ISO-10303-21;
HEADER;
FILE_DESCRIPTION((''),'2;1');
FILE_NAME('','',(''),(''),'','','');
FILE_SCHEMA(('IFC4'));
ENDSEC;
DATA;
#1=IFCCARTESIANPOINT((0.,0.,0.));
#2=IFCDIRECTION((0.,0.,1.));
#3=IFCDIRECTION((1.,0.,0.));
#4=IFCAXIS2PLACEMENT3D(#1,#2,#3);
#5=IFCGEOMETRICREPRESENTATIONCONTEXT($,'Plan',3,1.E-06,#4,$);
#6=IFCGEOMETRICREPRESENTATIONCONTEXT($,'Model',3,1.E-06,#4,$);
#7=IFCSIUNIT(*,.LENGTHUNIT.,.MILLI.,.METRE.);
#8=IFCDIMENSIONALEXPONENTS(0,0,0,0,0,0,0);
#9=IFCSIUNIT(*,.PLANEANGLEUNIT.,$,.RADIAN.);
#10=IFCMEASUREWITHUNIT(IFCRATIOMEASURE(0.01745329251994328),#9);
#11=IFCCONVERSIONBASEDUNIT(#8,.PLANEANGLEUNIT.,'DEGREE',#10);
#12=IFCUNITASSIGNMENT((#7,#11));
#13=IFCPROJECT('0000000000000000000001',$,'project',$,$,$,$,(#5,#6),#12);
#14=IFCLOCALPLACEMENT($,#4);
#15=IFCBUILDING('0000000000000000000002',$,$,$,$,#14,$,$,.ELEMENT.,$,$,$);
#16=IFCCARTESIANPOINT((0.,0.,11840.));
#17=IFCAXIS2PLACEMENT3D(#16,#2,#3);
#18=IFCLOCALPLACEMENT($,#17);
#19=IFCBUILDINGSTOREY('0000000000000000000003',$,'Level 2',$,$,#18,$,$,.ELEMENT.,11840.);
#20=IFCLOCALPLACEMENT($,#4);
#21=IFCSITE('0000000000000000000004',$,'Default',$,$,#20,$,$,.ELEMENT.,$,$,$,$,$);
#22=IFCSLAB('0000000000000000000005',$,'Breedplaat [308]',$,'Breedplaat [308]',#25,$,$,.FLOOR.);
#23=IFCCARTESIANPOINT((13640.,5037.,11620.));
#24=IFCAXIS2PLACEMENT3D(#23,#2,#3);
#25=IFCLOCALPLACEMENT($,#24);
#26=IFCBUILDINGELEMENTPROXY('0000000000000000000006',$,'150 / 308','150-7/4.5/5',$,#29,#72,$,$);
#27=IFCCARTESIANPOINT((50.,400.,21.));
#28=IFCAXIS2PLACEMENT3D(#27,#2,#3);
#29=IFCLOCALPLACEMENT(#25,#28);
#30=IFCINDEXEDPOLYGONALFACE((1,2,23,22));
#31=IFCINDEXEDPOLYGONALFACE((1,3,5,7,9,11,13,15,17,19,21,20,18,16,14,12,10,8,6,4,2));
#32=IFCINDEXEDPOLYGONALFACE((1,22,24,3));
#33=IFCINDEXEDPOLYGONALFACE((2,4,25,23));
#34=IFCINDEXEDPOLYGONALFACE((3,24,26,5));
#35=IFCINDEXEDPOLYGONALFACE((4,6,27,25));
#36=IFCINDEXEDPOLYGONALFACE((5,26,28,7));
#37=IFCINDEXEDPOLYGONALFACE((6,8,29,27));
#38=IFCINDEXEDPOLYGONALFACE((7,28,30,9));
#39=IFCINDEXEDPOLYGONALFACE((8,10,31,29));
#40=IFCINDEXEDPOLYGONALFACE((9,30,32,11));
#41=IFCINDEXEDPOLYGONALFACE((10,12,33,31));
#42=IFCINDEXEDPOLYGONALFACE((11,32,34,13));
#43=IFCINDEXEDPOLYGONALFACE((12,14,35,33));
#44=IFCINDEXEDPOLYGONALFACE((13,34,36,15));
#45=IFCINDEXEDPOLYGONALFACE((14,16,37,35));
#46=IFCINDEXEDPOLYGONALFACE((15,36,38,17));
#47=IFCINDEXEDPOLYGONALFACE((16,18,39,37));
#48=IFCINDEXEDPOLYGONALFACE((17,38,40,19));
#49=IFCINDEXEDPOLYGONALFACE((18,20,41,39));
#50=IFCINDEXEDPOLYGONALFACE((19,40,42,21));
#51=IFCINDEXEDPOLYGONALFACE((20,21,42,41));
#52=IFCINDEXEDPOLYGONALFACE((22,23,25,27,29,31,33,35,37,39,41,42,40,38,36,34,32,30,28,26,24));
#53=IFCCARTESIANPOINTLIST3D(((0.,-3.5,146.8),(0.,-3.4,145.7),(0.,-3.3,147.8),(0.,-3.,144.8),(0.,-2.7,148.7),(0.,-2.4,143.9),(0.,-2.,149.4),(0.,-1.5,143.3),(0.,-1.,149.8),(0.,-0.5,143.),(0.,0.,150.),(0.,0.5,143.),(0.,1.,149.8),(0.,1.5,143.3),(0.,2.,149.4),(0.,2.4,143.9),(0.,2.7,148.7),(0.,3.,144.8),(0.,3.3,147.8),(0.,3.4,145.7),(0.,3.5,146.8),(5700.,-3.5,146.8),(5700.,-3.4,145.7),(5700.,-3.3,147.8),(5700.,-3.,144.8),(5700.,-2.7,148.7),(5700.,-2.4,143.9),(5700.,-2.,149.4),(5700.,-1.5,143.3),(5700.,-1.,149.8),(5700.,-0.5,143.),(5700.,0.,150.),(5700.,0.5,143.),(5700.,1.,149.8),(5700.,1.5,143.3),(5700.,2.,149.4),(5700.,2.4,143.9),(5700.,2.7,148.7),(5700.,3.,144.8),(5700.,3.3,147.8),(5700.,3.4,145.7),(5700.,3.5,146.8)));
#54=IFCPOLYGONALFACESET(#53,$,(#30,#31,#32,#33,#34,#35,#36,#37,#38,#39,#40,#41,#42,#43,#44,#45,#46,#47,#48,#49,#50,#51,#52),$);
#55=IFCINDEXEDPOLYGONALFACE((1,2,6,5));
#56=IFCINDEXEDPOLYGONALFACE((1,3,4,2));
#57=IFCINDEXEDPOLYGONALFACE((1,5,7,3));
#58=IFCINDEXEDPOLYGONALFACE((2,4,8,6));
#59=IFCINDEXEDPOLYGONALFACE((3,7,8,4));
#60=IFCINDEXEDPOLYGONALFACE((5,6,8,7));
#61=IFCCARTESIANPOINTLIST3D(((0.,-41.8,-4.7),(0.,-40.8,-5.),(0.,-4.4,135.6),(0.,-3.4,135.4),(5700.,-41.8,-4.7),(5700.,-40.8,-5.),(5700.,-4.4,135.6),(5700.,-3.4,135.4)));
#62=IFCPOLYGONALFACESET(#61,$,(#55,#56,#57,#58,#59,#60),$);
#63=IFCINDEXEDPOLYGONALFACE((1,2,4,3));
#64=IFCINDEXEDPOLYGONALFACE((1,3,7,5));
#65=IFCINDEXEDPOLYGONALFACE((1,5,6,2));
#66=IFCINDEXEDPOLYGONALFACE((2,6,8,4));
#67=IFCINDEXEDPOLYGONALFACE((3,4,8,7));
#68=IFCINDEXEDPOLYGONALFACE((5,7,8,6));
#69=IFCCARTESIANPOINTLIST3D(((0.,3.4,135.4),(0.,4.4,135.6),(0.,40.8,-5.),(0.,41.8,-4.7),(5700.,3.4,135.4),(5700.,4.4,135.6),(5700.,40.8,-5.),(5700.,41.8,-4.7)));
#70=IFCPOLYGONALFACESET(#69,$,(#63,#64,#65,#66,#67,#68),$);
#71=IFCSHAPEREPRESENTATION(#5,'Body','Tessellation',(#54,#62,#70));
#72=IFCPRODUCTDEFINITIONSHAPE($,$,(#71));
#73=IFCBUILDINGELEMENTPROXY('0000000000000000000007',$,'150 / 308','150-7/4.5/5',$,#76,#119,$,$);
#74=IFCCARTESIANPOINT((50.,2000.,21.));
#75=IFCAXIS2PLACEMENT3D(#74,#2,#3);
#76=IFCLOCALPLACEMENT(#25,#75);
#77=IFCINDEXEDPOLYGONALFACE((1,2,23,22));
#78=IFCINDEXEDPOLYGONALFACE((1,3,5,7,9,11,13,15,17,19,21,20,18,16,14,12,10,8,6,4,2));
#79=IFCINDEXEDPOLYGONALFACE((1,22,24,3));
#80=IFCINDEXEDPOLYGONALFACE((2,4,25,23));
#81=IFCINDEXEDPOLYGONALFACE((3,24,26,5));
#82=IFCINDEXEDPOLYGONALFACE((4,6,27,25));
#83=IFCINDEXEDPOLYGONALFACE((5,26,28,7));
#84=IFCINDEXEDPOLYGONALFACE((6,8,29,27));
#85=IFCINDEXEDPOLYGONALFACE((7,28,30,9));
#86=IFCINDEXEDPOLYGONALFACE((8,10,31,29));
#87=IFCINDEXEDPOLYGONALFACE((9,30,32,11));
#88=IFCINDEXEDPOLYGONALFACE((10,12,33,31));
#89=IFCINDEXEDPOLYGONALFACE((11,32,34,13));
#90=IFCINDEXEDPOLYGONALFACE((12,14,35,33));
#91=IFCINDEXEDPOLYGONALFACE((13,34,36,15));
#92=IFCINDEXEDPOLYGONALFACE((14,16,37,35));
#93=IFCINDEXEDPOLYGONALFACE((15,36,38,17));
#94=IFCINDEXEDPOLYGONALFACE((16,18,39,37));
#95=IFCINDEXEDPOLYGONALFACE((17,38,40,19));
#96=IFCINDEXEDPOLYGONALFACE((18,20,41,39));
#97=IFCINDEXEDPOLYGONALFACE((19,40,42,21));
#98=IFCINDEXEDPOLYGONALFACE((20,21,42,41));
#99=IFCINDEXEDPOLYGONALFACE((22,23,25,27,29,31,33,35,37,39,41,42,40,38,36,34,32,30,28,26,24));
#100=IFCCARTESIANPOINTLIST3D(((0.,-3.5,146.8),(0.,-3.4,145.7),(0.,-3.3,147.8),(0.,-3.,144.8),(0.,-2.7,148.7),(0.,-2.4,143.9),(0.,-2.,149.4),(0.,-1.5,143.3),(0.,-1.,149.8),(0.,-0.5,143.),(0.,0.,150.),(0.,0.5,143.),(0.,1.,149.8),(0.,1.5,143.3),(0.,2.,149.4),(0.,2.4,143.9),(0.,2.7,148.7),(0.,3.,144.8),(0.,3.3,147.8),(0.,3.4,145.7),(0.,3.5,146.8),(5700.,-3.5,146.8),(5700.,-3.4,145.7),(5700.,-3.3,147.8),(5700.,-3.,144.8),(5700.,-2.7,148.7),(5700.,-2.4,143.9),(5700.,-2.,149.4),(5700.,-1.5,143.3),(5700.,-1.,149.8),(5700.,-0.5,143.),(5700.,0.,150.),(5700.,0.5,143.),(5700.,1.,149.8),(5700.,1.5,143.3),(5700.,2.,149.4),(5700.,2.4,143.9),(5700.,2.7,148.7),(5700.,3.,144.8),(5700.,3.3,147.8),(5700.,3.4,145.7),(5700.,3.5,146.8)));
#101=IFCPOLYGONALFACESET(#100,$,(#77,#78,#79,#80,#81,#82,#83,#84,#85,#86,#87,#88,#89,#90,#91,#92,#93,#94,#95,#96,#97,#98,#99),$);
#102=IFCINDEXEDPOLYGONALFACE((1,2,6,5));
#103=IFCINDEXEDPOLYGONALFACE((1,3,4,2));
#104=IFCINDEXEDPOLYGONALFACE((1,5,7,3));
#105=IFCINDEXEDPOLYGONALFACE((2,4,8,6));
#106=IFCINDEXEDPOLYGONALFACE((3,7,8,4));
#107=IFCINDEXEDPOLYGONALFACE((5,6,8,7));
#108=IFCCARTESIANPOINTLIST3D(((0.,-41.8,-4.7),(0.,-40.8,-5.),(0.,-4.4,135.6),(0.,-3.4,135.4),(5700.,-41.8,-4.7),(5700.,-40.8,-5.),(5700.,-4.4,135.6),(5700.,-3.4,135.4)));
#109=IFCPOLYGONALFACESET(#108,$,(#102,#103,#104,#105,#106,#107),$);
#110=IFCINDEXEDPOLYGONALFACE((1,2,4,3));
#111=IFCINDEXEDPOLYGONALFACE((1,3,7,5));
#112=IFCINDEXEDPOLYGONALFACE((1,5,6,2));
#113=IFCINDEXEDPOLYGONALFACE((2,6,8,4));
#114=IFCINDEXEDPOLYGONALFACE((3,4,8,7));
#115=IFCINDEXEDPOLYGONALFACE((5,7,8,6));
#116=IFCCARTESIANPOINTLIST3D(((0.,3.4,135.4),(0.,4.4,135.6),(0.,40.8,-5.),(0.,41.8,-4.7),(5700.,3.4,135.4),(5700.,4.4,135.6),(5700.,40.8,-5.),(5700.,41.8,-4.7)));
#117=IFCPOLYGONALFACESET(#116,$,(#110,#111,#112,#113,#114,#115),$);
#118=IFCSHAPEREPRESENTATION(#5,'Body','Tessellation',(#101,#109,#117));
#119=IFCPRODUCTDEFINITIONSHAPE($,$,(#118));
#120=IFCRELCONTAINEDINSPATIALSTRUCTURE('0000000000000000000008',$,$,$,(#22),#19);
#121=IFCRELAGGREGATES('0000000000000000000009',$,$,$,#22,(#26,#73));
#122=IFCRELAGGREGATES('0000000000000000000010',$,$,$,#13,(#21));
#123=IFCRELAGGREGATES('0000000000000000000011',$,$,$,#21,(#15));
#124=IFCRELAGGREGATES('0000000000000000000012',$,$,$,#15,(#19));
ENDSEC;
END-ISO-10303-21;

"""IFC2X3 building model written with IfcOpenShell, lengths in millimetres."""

from ifc_helpers import new_model, entity, si_unit, converted_unit, frame, origin_with_axes, origin_2d_with_axis, place, context, project, spatial, rectangle, circle, extrude, element, aggregate, save


model = new_model("IFC2X3")

# Units and contexts
plan_context = context("Plan", 3, precision=1e-06, world=origin_with_axes())
model_context = context("Model", 3, precision=1e-06, world=origin_with_axes())
ifc_project = project(units=[si_unit("LENGTHUNIT", "METRE", prefix="MILLI"), converted_unit("PLANEANGLEUNIT", "DEGREE", entity("IfcRatioMeasure", 0.01745329251994328), si_unit("PLANEANGLEUNIT", "RADIAN"), dimensions=[0, 0, 0, 0, 0, 0, 0])], contexts=[plan_context, model_context])

# Site, building, storey
site_placement = place(None, origin_with_axes())
site = spatial("IfcSite", under=ifc_project, at=site_placement, Name="Default", CompositionType="ELEMENT")
building_placement = place(None, origin_with_axes())
building = spatial("IfcBuilding", under=site, at=building_placement, CompositionType="ELEMENT")
storey_placement = place(None, frame((0.0, 0.0, 11840.0), z_axis=(0.0, 0.0, 1.0), x_axis=(1.0, 0.0, 0.0)))
storey = spatial("IfcBuildingStorey", under=building, at=storey_placement, Name="Level 2", CompositionType="ELEMENT", Elevation=11840.0)

# Slab, building element proxies
slab_1_placement = place(None, frame((13640.0, 5037.0, 11620.0), z_axis=(0.0, 0.0, 1.0), x_axis=(1.0, 0.0, 0.0)))
slab_1 = element("IfcSlab", 1, at=slab_1_placement, inside=storey, Name="Breedplaat [308]", ObjectType="Breedplaat [308]", PredefinedType="FLOOR")
proxy_1_placement = place(slab_1_placement, frame((50.0, 400.0, 21.0), z_axis=(0.0, 0.0, 1.0), x_axis=(1.0, 0.0, 0.0)))
proxy_1 = element("IfcBuildingElementProxy", 2, at=proxy_1_placement, Name="150 / 308", Description="150-7/4.5/5", context=plan_context, shape_type="SweptSolid", body=[
    extrude(circle(Radius=3.5, at=origin_2d_with_axis()), frame((0.0, 0.0, 146.5), z_axis=(1.0, 0.0, 0.0), x_axis=(0.0, 0.0, 1.0)), (0.0, 0.0, 1.0), 5700.0),
    extrude(rectangle(XDim=145.2, YDim=1.0, at=origin_2d_with_axis()), frame((0.0, -22.6, 65.3), z_axis=(1.0, 0.0, 0.0), x_axis=(0.0, 0.257663, 0.966235)), (0.0, 0.0, 1.0), 5700.0),
    extrude(rectangle(XDim=145.2, YDim=1.0, at=origin_2d_with_axis()), frame((0.0, 22.6, 65.3), z_axis=(1.0, 0.0, 0.0), x_axis=(0.0, -0.257663, 0.966235)), (0.0, 0.0, 1.0), 5700.0),
])
proxy_2_placement = place(slab_1_placement, frame((50.0, 2000.0, 21.0), z_axis=(0.0, 0.0, 1.0), x_axis=(1.0, 0.0, 0.0)))
proxy_2 = element("IfcBuildingElementProxy", 3, at=proxy_2_placement, Name="150 / 308", Description="150-7/4.5/5", context=plan_context, shape_type="SweptSolid", body=[
    extrude(circle(Radius=3.5, at=origin_2d_with_axis()), frame((0.0, 0.0, 146.5), z_axis=(1.0, 0.0, 0.0), x_axis=(0.0, 0.0, 1.0)), (0.0, 0.0, 1.0), 5700.0),
    extrude(rectangle(XDim=145.2, YDim=1.0, at=origin_2d_with_axis()), frame((0.0, -22.6, 65.3), z_axis=(1.0, 0.0, 0.0), x_axis=(0.0, 0.257663, 0.966235)), (0.0, 0.0, 1.0), 5700.0),
    extrude(rectangle(XDim=145.2, YDim=1.0, at=origin_2d_with_axis()), frame((0.0, 22.6, 65.3), z_axis=(1.0, 0.0, 0.0), x_axis=(0.0, -0.257663, 0.966235)), (0.0, 0.0, 1.0), 5700.0),
])
aggregate(slab_1, [proxy_1, proxy_2])

save(model, "model.ifc")
